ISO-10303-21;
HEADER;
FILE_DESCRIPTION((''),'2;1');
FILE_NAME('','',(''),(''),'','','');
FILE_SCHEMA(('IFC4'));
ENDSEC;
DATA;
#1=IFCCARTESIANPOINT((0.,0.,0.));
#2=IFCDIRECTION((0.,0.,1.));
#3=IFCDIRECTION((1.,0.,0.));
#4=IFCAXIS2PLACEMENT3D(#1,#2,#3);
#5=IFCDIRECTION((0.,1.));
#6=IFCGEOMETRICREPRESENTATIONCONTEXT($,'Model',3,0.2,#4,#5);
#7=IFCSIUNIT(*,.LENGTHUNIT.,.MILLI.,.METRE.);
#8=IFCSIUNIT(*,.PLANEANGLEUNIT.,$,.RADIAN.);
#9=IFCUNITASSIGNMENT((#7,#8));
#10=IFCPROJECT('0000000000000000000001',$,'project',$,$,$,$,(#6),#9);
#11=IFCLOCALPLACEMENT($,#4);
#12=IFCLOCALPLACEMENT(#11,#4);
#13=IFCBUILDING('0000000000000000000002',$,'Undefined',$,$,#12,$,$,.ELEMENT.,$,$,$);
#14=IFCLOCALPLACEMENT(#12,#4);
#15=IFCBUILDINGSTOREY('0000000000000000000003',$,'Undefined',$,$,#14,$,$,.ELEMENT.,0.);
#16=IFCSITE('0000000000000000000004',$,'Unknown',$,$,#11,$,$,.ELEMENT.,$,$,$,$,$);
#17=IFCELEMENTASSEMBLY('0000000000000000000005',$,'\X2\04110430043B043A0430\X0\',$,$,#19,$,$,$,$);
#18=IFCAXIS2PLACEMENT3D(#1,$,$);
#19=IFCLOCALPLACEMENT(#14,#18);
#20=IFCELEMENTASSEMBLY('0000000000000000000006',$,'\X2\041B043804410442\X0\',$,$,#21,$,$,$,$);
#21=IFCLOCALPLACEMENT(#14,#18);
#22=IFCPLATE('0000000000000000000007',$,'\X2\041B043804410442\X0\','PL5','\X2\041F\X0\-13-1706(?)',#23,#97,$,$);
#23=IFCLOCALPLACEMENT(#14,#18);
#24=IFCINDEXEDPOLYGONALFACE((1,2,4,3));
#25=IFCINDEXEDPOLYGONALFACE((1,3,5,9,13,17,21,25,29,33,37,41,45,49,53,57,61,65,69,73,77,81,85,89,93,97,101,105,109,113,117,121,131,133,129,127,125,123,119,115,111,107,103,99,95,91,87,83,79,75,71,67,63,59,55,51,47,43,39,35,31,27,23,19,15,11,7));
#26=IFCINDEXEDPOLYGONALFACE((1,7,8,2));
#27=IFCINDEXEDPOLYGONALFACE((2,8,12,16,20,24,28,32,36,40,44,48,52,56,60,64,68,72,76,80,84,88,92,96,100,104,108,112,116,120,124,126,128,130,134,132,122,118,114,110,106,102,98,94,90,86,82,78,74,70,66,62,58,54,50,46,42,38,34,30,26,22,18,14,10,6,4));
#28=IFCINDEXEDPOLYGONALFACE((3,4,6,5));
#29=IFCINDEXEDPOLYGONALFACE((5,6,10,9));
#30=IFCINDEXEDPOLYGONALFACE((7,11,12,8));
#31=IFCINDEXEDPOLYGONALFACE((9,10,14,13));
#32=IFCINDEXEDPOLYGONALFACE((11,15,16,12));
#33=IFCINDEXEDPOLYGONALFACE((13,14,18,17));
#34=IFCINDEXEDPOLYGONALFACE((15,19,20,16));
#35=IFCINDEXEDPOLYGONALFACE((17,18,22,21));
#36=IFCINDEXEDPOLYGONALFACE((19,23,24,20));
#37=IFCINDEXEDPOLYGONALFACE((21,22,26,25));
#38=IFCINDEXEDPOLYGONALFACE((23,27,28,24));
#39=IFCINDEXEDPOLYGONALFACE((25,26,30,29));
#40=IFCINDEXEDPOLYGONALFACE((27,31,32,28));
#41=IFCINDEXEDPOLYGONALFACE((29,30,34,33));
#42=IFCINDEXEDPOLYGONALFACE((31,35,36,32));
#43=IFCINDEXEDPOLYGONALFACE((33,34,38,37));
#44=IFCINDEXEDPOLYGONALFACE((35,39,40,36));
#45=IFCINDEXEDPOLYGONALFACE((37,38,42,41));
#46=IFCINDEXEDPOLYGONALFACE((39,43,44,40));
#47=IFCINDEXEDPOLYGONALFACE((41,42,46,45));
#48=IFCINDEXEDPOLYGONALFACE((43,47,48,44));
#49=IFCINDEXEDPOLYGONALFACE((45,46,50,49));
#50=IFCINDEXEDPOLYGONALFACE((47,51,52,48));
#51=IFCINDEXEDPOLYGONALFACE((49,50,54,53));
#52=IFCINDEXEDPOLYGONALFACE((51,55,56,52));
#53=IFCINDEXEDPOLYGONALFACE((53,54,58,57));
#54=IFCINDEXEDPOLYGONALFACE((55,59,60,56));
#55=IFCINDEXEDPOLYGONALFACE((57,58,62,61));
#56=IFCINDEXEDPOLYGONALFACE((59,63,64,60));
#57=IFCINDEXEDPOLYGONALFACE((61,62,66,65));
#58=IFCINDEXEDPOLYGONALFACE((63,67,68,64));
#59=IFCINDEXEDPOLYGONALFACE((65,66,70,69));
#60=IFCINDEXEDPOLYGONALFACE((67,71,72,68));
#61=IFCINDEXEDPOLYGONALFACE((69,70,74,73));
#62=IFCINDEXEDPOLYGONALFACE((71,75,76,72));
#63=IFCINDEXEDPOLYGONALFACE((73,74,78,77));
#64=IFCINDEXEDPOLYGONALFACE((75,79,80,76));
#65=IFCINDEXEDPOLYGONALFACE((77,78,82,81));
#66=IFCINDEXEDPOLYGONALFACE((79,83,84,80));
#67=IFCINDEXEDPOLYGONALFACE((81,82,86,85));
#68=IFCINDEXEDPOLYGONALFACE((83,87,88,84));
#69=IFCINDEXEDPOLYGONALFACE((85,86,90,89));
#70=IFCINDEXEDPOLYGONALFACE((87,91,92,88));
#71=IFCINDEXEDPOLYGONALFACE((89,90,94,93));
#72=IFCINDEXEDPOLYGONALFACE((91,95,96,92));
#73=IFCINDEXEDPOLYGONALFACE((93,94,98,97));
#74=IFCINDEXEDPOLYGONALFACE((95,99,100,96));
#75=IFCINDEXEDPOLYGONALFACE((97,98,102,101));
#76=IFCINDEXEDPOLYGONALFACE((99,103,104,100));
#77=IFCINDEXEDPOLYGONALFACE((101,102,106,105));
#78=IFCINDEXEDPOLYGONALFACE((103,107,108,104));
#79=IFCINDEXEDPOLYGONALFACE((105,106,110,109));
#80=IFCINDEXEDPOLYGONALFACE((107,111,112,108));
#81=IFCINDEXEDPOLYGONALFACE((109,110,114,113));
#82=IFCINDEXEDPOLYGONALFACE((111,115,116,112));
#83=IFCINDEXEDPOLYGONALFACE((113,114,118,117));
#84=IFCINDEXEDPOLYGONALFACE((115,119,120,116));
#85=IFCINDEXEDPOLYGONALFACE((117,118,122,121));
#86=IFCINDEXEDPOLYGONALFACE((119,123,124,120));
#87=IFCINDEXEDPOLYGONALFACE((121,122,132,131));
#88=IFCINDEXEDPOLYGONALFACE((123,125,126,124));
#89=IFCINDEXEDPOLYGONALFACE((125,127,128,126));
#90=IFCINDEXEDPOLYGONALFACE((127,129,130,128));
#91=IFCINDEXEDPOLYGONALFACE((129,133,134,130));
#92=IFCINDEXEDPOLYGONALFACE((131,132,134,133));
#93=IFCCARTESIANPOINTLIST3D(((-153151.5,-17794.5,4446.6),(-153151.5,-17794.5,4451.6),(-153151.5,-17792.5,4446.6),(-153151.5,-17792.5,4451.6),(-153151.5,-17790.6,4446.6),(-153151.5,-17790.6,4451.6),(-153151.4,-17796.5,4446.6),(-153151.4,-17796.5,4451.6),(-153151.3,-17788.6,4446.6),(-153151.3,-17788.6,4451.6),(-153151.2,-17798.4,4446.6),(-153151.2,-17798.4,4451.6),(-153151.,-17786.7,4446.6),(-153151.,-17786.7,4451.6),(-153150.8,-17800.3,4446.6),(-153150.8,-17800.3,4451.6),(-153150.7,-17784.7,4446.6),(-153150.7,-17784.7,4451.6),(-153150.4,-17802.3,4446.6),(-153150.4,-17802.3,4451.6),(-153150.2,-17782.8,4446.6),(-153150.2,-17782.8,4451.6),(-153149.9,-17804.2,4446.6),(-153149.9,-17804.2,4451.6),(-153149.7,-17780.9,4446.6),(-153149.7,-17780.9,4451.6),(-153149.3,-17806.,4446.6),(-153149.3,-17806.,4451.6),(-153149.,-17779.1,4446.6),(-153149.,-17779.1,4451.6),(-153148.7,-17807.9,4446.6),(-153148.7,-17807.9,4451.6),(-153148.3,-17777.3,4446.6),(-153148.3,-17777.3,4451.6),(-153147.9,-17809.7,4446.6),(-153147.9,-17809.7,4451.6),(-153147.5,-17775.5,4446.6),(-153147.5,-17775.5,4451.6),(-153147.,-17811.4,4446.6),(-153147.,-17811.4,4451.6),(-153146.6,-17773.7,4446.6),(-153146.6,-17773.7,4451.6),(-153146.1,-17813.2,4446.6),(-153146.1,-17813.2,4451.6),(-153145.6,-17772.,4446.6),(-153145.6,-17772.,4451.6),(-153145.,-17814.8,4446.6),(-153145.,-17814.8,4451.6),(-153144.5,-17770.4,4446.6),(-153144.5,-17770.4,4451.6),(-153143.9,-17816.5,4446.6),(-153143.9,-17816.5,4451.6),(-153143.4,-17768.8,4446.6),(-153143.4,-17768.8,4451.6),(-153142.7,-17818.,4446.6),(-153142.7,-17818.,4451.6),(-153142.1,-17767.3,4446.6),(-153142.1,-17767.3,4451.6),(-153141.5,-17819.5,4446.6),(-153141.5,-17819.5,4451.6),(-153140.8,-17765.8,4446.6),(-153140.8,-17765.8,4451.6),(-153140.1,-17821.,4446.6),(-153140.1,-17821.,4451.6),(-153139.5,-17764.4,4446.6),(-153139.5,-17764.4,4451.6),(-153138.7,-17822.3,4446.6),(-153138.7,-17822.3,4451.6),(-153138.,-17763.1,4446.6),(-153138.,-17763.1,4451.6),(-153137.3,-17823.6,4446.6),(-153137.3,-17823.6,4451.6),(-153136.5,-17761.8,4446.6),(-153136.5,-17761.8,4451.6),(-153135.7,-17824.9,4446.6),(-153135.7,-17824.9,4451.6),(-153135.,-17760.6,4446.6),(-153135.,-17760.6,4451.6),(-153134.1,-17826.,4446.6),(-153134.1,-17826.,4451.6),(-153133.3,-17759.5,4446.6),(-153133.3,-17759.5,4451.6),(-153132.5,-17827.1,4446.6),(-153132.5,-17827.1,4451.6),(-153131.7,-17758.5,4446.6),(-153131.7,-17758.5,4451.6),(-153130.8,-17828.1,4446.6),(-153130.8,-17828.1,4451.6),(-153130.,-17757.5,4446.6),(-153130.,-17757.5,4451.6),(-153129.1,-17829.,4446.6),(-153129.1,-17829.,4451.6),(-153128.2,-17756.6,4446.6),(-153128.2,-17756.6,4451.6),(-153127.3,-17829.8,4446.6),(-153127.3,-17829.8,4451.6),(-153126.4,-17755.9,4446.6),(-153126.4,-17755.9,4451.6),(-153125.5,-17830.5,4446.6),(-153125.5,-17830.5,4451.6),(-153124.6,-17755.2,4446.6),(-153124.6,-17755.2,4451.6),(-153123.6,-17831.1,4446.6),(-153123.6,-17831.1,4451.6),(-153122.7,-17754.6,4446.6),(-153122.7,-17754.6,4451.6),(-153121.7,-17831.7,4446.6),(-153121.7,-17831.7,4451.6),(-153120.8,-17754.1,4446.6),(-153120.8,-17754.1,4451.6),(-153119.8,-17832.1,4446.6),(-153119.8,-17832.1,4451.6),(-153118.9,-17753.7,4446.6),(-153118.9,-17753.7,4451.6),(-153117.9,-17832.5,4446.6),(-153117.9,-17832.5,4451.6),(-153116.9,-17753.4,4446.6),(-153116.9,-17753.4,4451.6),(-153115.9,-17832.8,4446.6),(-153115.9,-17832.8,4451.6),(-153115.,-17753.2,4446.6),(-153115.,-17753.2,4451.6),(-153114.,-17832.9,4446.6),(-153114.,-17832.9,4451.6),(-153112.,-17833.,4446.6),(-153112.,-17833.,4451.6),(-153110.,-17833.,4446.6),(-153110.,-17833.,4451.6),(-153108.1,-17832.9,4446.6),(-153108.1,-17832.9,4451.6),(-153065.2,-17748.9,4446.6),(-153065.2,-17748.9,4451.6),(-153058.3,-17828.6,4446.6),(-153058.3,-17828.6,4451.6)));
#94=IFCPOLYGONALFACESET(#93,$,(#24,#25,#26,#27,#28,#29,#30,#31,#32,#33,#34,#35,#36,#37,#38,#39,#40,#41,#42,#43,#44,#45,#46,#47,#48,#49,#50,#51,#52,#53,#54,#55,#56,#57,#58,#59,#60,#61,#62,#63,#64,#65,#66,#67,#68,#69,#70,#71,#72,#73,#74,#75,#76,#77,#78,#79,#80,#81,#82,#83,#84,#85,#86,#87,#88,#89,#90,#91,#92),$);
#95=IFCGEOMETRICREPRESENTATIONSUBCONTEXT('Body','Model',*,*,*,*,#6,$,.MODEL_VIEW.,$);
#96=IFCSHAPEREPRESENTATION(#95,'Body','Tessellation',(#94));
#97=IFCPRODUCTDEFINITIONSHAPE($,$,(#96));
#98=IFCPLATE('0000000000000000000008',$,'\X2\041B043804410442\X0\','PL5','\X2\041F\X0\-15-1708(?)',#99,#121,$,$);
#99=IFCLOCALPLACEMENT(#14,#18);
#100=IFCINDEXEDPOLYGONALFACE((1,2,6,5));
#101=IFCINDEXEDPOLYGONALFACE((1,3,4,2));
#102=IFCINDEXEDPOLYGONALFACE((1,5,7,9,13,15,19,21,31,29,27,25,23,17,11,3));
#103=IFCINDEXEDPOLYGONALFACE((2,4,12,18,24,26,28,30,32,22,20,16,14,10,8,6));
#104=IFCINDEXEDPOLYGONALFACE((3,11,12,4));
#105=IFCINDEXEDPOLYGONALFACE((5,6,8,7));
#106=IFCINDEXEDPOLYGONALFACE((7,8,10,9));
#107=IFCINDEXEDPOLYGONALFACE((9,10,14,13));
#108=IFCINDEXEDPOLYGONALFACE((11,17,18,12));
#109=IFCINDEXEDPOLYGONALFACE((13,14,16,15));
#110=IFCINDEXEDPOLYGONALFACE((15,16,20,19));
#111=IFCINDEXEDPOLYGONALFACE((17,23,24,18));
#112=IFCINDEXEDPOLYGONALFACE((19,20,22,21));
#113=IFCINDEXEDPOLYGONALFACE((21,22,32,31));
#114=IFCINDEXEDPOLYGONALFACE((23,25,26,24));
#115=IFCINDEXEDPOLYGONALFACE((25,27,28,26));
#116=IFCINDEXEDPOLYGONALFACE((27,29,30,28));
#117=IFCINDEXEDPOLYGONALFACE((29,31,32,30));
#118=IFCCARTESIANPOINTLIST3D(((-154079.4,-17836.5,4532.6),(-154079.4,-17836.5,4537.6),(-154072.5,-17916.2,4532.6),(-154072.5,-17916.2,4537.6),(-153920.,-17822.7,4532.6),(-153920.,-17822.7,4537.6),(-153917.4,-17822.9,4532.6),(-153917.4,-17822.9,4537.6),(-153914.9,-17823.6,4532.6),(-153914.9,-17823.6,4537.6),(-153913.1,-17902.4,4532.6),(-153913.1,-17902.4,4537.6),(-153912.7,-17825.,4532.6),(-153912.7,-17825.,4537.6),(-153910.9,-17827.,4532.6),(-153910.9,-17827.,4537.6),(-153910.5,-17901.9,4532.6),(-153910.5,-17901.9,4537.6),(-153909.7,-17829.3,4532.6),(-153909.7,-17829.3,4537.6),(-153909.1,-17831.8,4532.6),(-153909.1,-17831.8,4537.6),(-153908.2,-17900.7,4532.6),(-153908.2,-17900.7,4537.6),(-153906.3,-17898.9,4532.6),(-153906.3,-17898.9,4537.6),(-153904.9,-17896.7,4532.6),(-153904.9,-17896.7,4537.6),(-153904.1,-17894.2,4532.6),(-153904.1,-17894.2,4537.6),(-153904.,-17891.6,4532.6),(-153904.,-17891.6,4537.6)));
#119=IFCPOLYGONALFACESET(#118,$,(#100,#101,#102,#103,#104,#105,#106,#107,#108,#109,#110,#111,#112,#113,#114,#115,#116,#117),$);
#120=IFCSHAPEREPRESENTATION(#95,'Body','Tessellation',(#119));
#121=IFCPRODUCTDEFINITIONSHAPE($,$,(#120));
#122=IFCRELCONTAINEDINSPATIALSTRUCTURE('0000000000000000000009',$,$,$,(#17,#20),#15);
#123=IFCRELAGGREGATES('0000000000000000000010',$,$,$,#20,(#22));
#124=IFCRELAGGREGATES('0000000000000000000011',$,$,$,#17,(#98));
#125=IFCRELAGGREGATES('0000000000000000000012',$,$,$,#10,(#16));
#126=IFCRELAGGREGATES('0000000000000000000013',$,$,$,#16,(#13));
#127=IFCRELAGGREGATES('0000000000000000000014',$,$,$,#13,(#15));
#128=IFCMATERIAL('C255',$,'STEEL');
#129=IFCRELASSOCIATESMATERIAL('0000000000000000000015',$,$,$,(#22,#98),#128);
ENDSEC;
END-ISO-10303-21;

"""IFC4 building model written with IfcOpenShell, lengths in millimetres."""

from ifc_helpers import new_model, si_unit, direction, frame, origin_with_axes, place, context, subcontext, project, spatial, line, arc, indexed_curve, outline, extrude, material, element, aggregate, save


model = new_model("IFC4")

# Units and contexts
model_context = context("Model", 3, precision=0.2, world=origin_with_axes(), true_north=direction((0.0, 1.0)))
body_context = subcontext(model_context, "Body", "Model", "MODEL_VIEW")
ifc_project = project(units=[si_unit("LENGTHUNIT", "METRE", prefix="MILLI"), si_unit("PLANEANGLEUNIT", "RADIAN")], contexts=[model_context])

# Site, building, storey
site_placement = place(None, origin_with_axes())
site = spatial("IfcSite", under=ifc_project, at=site_placement, Name="Unknown", CompositionType="ELEMENT")
building_placement = place(site_placement, origin_with_axes())
building = spatial("IfcBuilding", under=site, at=building_placement, Name="Undefined", CompositionType="ELEMENT")
storey_placement = place(building_placement, origin_with_axes())
storey = spatial("IfcBuildingStorey", under=building, at=storey_placement, Name="Undefined", CompositionType="ELEMENT", Elevation=0.0)

# Element assembly
assembly_1_placement = place(storey_placement, frame((-154078.4, -17876.6, 4581.6), z_axis=(0.996285, 0.086114, 0.0), x_axis=(0.0, 0.0, -1.0)))
assembly_1 = element("IfcElementAssembly", 1, at=assembly_1_placement, inside=storey, Name="Балка")
ifc_material_1 = material(Name="C255", Category="STEEL")

# Element assembly, plate
assembly_2_placement = place(storey_placement, frame((-153051.5, -17878.2, 4406.6), z_axis=(-0.996285, -0.086114, 0.0), x_axis=(0.0, 0.0, 1.0)))
assembly_2 = element("IfcElementAssembly", 2, at=assembly_2_placement, inside=storey, Name="Лист")
plate_1_placement = place(assembly_2_placement, frame((42.5, 50.0, 2.5), z_axis=(1.0, 0.0, 0.0), x_axis=(0.0, 1.0, 0.0)))
plate_1 = element("IfcPlate", 3, at=plate_1_placement, material=ifc_material_1, Name="Лист", Description="PL5", ObjectType="П-13-1706(?)", context=body_context, shape_type="SolidModel", body=[
    extrude(outline(indexed_curve([(0.0, 0.0), (80.0, 0.0), (80.0, 50.0), (80.0, 52.0), (79.8, 53.9), (79.6, 55.9), (79.2, 57.8), (78.8, 59.7), (78.3, 61.6), (77.7, 63.5), (77.0, 65.3), (76.2, 67.1), (75.3, 68.9), (74.3, 70.6), (73.3, 72.2), (72.1, 73.8), (70.9, 75.4), (69.6, 76.9), (68.3, 78.3), (66.9, 79.6), (65.4, 80.9), (63.8, 82.1), (62.2, 83.3), (60.6, 84.3), (58.9, 85.3), (57.1, 86.2), (55.3, 87.0), (53.5, 87.7), (51.6, 88.3), (49.7, 88.8), (47.8, 89.2), (45.9, 89.6), (43.9, 89.8), (42.0, 90.0), (40.0, 90.0), (40.0, 90.0), (38.0, 90.0), (36.1, 89.8), (34.1, 89.6), (32.2, 89.2), (30.3, 88.8), (28.4, 88.3), (26.5, 87.7), (24.7, 87.0), (22.9, 86.2), (21.1, 85.3), (19.4, 84.3), (17.8, 83.3), (16.2, 82.1), (14.6, 80.9), (13.1, 79.6), (11.7, 78.3), (10.4, 76.9), (9.1, 75.4), (7.9, 73.8), (6.7, 72.2), (5.7, 70.6), (4.7, 68.9), (3.8, 67.1), (3.0, 65.3), (2.3, 63.5), (1.7, 61.6), (1.2, 59.7), (0.8, 57.8), (0.4, 55.9), (0.2, 53.9), (0.0, 52.0), (0.0, 50.0)], segments=[line(1, 2, 3, 4, 5, 6, 7, 8, 9, 10, 11, 12, 13, 14, 15, 16, 17, 18, 19, 20, 21, 22, 23, 24, 25, 26, 27, 28, 29, 30, 31, 32, 33, 34, 35, 36, 37, 38, 39, 40, 41, 42, 43, 44, 45, 46, 47, 48, 49, 50, 51, 52, 53, 54, 55, 56, 57, 58, 59, 60, 61, 62, 63, 64, 65, 66, 67, 68, 1)])), frame((0.0, 0.0, 2.5), z_axis=(0.0, 0.0, 1.0), x_axis=(1.0, 0.0, 0.0)), (0.0, 0.0, -1.0), 5.0),
])

# Plate
plate_2_placement = place(assembly_1_placement, frame((46.5, 40.0, 2.5), z_axis=(-1.0, 0.0, 0.0), x_axis=(0.0, -1.0, 0.0)))
plate_2 = element("IfcPlate", 4, at=plate_2_placement, material=ifc_material_1, Name="Лист", Description="PL5", ObjectType="П-15-1708(?)", context=body_context, shape_type="SolidModel", body=[
    extrude(outline(indexed_curve([(0.0, 0.0), (80.0, 0.0), (80.0, 160.0), (77.1, 167.1), (70.0, 170.0), (10.0, 170.0), (2.9, 167.1), (0.0, 160.0)], segments=[line(1, 2, 3), arc(3, 4, 5), line(5, 6), arc(6, 7, 8), line(8, 1)])), frame((0.0, 0.0, 2.5), z_axis=(0.0, 0.0, 1.0), x_axis=(1.0, 0.0, 0.0)), (0.0, 0.0, -1.0), 5.0),
])

aggregate(assembly_2, [plate_1])
aggregate(assembly_1, [plate_2])

save(model, "model.ifc")
